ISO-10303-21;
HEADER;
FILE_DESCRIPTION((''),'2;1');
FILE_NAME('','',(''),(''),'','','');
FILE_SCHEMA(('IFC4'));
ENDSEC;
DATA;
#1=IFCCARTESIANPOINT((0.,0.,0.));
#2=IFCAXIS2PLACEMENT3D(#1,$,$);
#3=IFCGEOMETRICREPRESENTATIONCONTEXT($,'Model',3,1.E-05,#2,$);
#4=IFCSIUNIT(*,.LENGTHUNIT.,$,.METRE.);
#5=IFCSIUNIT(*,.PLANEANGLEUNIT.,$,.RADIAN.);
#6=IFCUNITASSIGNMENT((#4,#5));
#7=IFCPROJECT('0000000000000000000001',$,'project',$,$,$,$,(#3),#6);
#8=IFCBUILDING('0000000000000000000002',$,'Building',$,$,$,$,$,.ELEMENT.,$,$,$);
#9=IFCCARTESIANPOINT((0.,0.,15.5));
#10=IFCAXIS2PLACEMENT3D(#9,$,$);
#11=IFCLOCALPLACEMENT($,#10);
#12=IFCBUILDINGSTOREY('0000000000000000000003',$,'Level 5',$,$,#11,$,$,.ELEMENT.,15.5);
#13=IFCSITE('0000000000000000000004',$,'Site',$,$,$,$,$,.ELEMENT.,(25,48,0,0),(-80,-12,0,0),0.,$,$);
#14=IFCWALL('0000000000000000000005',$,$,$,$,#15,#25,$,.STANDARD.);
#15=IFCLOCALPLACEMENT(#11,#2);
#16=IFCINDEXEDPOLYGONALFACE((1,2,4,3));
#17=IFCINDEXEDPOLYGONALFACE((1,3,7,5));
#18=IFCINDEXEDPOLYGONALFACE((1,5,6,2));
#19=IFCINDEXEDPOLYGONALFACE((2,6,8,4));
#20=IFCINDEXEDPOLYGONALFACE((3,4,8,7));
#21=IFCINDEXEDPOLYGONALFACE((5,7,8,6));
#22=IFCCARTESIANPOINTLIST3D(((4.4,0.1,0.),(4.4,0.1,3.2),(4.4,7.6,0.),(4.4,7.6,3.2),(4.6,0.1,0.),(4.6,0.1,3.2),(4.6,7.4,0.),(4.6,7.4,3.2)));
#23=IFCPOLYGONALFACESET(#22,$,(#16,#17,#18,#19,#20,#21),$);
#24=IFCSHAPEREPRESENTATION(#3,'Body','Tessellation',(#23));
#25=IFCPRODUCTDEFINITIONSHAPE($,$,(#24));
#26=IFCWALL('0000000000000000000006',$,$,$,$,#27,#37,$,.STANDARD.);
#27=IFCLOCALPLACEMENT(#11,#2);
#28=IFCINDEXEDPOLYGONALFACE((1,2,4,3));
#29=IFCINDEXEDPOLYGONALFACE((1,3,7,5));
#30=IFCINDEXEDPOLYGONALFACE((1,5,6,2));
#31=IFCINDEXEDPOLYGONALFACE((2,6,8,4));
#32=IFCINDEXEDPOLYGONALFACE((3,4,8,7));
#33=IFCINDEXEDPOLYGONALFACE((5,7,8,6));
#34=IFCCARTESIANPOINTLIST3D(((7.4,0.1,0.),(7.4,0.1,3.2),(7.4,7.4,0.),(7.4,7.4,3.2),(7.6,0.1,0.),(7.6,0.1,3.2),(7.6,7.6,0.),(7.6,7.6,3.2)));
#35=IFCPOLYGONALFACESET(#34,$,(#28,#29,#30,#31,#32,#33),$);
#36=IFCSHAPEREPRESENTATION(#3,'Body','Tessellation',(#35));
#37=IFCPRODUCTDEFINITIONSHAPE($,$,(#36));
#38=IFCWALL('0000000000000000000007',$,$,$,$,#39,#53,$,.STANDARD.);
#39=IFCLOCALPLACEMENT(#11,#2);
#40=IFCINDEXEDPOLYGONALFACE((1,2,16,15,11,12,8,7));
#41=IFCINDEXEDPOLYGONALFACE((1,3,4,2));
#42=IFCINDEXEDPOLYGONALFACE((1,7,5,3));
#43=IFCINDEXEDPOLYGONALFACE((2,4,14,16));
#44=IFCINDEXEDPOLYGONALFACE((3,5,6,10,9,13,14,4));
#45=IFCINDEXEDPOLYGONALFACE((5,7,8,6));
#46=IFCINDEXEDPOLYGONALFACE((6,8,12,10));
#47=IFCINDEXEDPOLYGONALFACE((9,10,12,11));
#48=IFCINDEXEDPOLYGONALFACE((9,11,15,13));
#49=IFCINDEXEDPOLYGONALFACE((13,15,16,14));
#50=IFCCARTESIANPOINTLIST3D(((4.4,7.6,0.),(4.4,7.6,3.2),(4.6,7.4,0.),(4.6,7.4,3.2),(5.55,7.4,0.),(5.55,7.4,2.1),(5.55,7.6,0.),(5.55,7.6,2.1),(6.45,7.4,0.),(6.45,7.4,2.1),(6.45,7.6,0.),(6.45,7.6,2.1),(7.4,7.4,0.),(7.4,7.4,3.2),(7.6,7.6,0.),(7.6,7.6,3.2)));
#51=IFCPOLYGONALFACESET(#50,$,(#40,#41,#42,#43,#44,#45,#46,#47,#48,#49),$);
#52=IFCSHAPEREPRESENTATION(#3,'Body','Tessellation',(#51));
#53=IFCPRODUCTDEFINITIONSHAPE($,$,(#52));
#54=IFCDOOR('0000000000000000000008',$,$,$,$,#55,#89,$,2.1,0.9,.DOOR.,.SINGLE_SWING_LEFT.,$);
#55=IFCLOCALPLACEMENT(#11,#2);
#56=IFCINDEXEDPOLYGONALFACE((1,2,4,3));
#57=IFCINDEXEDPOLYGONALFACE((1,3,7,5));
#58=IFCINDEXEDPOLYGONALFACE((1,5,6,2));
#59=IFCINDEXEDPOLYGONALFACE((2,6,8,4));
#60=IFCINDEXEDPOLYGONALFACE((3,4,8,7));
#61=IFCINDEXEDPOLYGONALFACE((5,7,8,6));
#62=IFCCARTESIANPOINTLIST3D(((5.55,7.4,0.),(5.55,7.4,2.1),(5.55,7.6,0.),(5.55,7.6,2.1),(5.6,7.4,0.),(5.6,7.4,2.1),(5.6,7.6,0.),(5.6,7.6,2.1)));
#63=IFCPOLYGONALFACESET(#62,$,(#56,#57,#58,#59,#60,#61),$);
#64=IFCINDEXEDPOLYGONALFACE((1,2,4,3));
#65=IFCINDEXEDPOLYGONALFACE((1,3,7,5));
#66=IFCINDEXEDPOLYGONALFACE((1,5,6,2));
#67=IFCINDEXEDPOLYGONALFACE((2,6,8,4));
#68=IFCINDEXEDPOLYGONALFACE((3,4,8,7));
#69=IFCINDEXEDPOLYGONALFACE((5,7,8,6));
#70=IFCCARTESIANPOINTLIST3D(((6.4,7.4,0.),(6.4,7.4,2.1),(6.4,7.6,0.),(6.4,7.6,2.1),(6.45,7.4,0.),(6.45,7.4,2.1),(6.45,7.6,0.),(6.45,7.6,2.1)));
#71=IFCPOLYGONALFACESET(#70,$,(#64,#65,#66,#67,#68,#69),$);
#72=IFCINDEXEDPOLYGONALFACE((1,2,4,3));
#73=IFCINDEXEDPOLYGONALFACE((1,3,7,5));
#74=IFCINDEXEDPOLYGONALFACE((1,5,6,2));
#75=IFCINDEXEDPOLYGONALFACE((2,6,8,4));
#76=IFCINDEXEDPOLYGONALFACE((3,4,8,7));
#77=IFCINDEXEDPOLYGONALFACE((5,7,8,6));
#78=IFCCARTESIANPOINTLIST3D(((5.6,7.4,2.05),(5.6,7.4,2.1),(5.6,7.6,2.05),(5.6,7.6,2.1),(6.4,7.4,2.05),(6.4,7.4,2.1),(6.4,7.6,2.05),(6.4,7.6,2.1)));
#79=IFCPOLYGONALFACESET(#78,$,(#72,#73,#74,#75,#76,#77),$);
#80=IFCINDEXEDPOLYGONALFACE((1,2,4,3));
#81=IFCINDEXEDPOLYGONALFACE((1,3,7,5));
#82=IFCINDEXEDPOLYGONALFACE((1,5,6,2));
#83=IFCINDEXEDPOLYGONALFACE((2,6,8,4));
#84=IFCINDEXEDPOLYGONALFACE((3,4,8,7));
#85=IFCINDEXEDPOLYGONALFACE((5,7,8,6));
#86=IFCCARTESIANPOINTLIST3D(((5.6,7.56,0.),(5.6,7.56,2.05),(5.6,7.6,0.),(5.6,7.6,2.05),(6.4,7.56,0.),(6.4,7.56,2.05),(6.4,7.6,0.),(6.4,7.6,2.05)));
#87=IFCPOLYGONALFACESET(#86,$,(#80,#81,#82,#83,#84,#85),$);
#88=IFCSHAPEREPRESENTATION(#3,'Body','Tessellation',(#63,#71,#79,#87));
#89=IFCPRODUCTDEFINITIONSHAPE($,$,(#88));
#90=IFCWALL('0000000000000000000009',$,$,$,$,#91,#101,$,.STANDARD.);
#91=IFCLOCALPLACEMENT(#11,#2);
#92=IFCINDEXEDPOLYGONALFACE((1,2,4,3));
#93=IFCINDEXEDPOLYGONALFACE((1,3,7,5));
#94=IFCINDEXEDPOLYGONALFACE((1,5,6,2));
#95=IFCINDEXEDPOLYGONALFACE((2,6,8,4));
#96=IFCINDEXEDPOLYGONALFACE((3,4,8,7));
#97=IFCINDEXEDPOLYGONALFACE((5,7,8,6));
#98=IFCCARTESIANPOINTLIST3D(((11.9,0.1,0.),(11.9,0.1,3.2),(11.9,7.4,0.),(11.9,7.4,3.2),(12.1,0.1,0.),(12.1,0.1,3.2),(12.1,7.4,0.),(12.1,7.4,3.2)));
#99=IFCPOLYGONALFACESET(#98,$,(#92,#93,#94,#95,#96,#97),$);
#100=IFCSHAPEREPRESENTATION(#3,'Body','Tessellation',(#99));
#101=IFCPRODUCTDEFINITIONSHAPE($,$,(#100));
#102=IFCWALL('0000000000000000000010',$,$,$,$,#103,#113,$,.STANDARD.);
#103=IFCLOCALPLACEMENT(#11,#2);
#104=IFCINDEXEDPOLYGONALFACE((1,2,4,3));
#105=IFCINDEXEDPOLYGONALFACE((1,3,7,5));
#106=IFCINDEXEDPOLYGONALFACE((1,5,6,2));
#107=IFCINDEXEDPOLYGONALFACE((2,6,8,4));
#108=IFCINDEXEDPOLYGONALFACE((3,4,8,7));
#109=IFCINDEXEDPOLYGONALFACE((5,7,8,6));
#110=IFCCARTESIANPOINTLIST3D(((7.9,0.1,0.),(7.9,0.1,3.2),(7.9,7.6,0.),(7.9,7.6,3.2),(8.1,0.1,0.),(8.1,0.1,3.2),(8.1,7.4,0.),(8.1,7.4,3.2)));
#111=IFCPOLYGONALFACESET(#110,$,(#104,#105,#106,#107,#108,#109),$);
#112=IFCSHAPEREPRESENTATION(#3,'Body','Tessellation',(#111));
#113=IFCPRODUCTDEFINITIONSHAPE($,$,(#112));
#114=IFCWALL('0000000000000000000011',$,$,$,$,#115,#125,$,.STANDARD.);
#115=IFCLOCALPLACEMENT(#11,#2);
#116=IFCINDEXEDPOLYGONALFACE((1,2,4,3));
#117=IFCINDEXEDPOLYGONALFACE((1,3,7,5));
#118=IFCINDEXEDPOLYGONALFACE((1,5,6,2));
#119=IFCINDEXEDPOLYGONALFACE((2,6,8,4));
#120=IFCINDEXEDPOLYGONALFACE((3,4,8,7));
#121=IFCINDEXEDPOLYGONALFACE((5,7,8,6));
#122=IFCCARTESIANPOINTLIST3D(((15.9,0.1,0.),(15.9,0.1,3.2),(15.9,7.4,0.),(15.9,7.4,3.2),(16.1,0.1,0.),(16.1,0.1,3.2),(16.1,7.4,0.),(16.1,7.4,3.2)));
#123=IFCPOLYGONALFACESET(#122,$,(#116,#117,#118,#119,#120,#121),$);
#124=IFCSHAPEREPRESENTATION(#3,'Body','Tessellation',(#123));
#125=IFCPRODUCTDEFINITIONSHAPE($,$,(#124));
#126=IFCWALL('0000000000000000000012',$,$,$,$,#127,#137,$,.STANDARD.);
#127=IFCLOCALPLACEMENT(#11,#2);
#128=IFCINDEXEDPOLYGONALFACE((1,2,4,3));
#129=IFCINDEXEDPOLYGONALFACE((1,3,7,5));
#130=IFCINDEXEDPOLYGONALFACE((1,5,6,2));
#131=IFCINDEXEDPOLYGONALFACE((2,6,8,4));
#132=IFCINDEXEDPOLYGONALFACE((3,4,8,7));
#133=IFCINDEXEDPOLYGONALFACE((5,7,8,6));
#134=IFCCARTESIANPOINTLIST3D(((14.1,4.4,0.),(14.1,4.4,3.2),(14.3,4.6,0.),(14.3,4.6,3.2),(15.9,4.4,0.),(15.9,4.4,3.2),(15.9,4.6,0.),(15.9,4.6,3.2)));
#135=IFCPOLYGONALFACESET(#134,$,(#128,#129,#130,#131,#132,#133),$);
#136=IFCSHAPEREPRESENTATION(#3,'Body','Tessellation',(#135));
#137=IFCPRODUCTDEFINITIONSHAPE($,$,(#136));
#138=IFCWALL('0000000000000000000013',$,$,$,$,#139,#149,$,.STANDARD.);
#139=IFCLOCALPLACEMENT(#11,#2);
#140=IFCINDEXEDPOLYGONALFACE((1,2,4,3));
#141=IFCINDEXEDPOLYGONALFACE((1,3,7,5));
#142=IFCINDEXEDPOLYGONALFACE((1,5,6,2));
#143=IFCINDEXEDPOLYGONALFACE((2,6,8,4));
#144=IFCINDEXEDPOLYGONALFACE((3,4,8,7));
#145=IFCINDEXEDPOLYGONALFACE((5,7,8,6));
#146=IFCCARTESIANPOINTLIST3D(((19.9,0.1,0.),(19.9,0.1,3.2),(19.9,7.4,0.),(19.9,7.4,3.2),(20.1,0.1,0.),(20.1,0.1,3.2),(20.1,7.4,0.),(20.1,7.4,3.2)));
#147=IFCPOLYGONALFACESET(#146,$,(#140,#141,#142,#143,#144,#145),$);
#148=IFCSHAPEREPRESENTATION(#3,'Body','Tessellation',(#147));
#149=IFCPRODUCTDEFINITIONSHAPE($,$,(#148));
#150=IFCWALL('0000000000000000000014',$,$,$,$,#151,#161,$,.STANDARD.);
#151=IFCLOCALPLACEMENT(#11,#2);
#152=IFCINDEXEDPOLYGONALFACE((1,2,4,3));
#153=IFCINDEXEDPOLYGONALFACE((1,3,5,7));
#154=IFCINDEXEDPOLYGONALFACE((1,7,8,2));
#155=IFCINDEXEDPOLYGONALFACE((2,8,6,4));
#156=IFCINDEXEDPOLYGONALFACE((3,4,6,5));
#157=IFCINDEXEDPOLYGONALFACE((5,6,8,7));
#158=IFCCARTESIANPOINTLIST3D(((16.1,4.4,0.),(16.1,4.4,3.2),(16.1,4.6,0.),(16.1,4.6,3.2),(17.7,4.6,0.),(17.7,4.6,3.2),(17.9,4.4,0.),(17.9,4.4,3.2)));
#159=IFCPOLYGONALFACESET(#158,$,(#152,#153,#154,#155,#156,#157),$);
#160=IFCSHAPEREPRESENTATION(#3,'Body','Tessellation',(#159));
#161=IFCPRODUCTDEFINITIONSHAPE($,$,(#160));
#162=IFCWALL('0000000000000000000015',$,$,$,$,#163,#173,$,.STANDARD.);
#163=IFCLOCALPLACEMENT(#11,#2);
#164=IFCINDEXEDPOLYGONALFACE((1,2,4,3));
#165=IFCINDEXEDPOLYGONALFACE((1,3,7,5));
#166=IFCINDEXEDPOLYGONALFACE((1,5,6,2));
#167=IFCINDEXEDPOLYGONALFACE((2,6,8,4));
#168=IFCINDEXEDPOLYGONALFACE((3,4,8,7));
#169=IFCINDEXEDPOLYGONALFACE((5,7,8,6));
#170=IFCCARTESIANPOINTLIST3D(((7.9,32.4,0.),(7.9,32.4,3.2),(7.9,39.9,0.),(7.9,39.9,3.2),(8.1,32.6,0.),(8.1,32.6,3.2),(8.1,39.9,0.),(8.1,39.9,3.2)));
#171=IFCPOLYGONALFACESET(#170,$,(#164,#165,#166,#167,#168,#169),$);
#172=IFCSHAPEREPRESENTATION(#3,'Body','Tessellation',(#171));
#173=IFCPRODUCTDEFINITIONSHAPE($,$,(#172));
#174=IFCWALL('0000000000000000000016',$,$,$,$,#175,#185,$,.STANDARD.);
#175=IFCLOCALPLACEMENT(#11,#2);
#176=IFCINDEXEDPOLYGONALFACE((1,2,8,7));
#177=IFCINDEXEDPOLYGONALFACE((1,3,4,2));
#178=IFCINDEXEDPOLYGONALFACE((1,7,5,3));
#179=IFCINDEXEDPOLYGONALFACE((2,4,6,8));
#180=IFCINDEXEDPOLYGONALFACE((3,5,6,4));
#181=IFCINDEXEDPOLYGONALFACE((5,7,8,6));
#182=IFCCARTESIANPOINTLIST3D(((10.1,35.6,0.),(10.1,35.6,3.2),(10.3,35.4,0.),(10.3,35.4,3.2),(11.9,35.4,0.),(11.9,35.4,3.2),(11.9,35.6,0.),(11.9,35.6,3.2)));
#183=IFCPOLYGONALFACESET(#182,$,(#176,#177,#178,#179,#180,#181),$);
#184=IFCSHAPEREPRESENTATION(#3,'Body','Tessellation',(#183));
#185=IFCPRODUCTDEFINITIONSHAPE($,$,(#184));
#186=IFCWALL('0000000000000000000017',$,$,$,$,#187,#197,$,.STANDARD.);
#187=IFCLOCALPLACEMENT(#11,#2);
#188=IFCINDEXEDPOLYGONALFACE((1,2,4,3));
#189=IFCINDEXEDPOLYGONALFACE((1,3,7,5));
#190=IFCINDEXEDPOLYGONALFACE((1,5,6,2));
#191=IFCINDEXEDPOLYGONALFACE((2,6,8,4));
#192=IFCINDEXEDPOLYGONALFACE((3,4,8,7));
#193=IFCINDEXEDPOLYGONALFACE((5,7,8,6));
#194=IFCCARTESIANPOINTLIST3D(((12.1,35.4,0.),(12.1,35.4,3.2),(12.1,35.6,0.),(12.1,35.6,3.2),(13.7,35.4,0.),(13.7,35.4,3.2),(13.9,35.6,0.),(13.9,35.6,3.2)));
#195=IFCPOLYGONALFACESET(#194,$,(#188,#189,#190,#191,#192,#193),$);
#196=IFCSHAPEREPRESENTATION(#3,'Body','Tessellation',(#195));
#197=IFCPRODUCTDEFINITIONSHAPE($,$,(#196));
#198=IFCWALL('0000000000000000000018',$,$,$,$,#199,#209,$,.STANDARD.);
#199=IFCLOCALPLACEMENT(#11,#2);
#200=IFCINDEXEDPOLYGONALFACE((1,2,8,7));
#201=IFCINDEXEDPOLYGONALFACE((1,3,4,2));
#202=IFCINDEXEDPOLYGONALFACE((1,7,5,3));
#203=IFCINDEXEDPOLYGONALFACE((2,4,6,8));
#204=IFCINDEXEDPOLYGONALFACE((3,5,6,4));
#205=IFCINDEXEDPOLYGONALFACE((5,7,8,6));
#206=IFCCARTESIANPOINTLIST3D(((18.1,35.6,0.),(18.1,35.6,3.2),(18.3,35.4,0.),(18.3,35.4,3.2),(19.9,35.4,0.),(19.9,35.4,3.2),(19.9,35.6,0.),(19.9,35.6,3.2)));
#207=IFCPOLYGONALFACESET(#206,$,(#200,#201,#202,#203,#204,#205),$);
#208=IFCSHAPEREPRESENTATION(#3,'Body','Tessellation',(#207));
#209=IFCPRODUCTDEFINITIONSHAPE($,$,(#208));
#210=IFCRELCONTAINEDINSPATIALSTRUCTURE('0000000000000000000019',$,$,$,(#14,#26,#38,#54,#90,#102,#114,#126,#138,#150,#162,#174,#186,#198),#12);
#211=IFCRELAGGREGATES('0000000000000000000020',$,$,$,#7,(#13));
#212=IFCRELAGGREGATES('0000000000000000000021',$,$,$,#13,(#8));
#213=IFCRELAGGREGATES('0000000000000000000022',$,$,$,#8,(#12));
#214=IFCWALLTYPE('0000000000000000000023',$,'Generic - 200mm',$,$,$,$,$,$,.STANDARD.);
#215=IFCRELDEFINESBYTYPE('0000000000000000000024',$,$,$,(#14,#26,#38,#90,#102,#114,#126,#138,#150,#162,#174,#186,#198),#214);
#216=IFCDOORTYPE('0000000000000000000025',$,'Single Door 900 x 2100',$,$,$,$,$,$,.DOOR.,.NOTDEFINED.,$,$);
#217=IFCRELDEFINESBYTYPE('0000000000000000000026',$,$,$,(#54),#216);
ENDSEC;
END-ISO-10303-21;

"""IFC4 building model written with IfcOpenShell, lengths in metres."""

from ifc_helpers import new_model, si_unit, frame, frame_2d, origin, origin_with_axes, origin_2d, place, context, project, spatial, polyline, rectangle, outline, extrude, type_object, element, fill, save


model = new_model("IFC4")

# Units and contexts
model_context = context("Model", 3, precision=1e-05, world=origin())
ifc_project = project(units=[si_unit("LENGTHUNIT", "METRE"), si_unit("PLANEANGLEUNIT", "RADIAN")], contexts=[model_context])

# Site, building, storey
site = spatial("IfcSite", under=ifc_project, Name="Site", CompositionType="ELEMENT", RefLatitude=(25, 48, 0, 0), RefLongitude=(-80, -12, 0, 0), RefElevation=0.0)
building = spatial("IfcBuilding", under=site, Name="Building", CompositionType="ELEMENT")
storey_placement = place(None, frame((0.0, 0.0, 15.5)))
storey = spatial("IfcBuildingStorey", under=building, at=storey_placement, Name="Level 5", CompositionType="ELEMENT", Elevation=15.5)

# Shared definitions
wall_type = type_object("IfcWallType", Name="Generic - 200mm", PredefinedType="STANDARD")

# Walls
wall_1_placement = place(None, frame((4.5, 7.5, 15.5), z_axis=(0.0, 0.0, 1.0), x_axis=(0.0, -1.0, 0.0)))
element("IfcWall", 1, at=wall_1_placement, inside=storey, type_object=wall_type, PredefinedType="STANDARD", context=model_context, shape_type="SweptSolid", body=[
    extrude(outline(polyline([(-0.1, -0.1), (7.4, -0.1), (7.4, 0.1), (0.1, 0.1), (-0.1, -0.1)])), origin(), (0.0, 0.0, 1.0), 3.2),
])
wall_2_placement = place(None, frame((7.5, 7.5, 15.5), z_axis=(0.0, 0.0, 1.0), x_axis=(0.0, -1.0, 0.0)))
element("IfcWall", 2, at=wall_2_placement, inside=storey, type_object=wall_type, PredefinedType="STANDARD", context=model_context, shape_type="SweptSolid", body=[
    extrude(outline(polyline([(0.1, -0.1), (7.4, -0.1), (7.4, 0.1), (-0.1, 0.1), (0.1, -0.1)])), origin(), (0.0, 0.0, 1.0), 3.2),
])

# Wall, opening, door
wall_3_placement = place(None, frame((4.5, 7.5, 15.5), z_axis=(0.0, 0.0, 1.0), x_axis=(1.0, 0.0, 0.0)))
wall_3 = element("IfcWall", 3, at=wall_3_placement, inside=storey, type_object=wall_type, PredefinedType="STANDARD", context=model_context, shape_type="SweptSolid", body=[
    extrude(outline(polyline([(0.1, -0.1), (2.9, -0.1), (3.1, 0.1), (-0.1, 0.1), (0.1, -0.1)])), origin(), (0.0, 0.0, 1.0), 3.2),
])
opening_1_placement = place(wall_3_placement, frame((1.5, 0.0, 0.0), z_axis=(0.0, 0.0, 1.0), x_axis=(1.0, 0.0, 0.0)))
opening_1 = element("IfcOpeningElement", 4, at=opening_1_placement, cuts=wall_3, PredefinedType="OPENING", context=model_context, shape_type="SweptSolid", body=[
    extrude(rectangle(XDim=0.9, YDim=0.202, at=origin_2d()), origin(), (0.0, 0.0, 1.0), 2.1),
])
door_type = type_object("IfcDoorType", Name="Single Door 900 x 2100", OperationType="NOTDEFINED", PredefinedType="DOOR")
door_placement = place(opening_1_placement, origin_with_axes())
door = element("IfcDoor", 5, at=door_placement, inside=storey, type_object=door_type, OperationType="SINGLE_SWING_LEFT", OverallHeight=2.1, OverallWidth=0.9, PredefinedType="DOOR", context=model_context, shape_type="SweptSolid", body=[
    extrude(rectangle(XDim=0.05, YDim=0.2, at=frame_2d((-0.425, 0.0))), origin(), (0.0, 0.0, 1.0), 2.1),
    extrude(rectangle(XDim=0.05, YDim=0.2, at=frame_2d((0.425, 0.0))), origin(), (0.0, 0.0, 1.0), 2.1),
    extrude(rectangle(XDim=0.8, YDim=0.2, at=origin_2d()), frame((0.0, 0.0, 2.05)), (0.0, 0.0, 1.0), 0.05),
    extrude(rectangle(XDim=0.8, YDim=0.04, at=frame_2d((0.0, 0.08))), origin(), (0.0, 0.0, 1.0), 2.05),
])
fill(opening_1, door)

# Walls
wall_4_placement = place(None, frame((12.0, 7.5, 15.5), z_axis=(0.0, 0.0, 1.0), x_axis=(0.0, -1.0, 0.0)))
element("IfcWall", 6, at=wall_4_placement, inside=storey, type_object=wall_type, PredefinedType="STANDARD", context=model_context, shape_type="SweptSolid", body=[
    extrude(outline(polyline([(0.1, -0.1), (7.4, -0.1), (7.4, 0.1), (0.1, 0.1), (0.1, -0.1)])), origin(), (0.0, 0.0, 1.0), 3.2),
])
wall_5_placement = place(None, frame((8.0, 7.5, 15.5), z_axis=(0.0, 0.0, 1.0), x_axis=(0.0, -1.0, 0.0)))
element("IfcWall", 7, at=wall_5_placement, inside=storey, type_object=wall_type, PredefinedType="STANDARD", context=model_context, shape_type="SweptSolid", body=[
    extrude(outline(polyline([(-0.1, -0.1), (7.4, -0.1), (7.4, 0.1), (0.1, 0.1), (-0.1, -0.1)])), origin(), (0.0, 0.0, 1.0), 3.2),
])
wall_6_placement = place(None, frame((16.0, 7.5, 15.5), z_axis=(0.0, 0.0, 1.0), x_axis=(0.0, -1.0, 0.0)))
element("IfcWall", 8, at=wall_6_placement, inside=storey, type_object=wall_type, PredefinedType="STANDARD", context=model_context, shape_type="SweptSolid", body=[
    extrude(outline(polyline([(0.1, -0.1), (7.4, -0.1), (7.4, 0.1), (0.1, 0.1), (0.1, -0.1)])), origin(), (0.0, 0.0, 1.0), 3.2),
])
wall_7_placement = place(None, frame((14.2, 4.5, 15.5), z_axis=(0.0, 0.0, 1.0), x_axis=(1.0, 0.0, 0.0)))
element("IfcWall", 9, at=wall_7_placement, inside=storey, type_object=wall_type, PredefinedType="STANDARD", context=model_context, shape_type="SweptSolid", body=[
    extrude(outline(polyline([(-0.1, -0.1), (1.7, -0.1), (1.7, 0.1), (0.1, 0.1), (-0.1, -0.1)])), origin(), (0.0, 0.0, 1.0), 3.2),
])
wall_8_placement = place(None, frame((20.0, 7.5, 15.5), z_axis=(0.0, 0.0, 1.0), x_axis=(0.0, -1.0, 0.0)))
element("IfcWall", 10, at=wall_8_placement, inside=storey, type_object=wall_type, PredefinedType="STANDARD", context=model_context, shape_type="SweptSolid", body=[
    extrude(outline(polyline([(0.1, -0.1), (7.4, -0.1), (7.4, 0.1), (0.1, 0.1), (0.1, -0.1)])), origin(), (0.0, 0.0, 1.0), 3.2),
])
wall_9_placement = place(None, frame((17.8, 4.5, 15.5), z_axis=(0.0, 0.0, 1.0), x_axis=(-1.0, 0.0, 0.0)))
element("IfcWall", 11, at=wall_9_placement, inside=storey, type_object=wall_type, PredefinedType="STANDARD", context=model_context, shape_type="SweptSolid", body=[
    extrude(outline(polyline([(0.1, -0.1), (1.7, -0.1), (1.7, 0.1), (-0.1, 0.1), (0.1, -0.1)])), origin(), (0.0, 0.0, 1.0), 3.2),
])
wall_10_placement = place(None, frame((8.0, 32.5, 15.5), z_axis=(0.0, 0.0, 1.0), x_axis=(0.0, 1.0, 0.0)))
element("IfcWall", 12, at=wall_10_placement, inside=storey, type_object=wall_type, PredefinedType="STANDARD", context=model_context, shape_type="SweptSolid", body=[
    extrude(outline(polyline([(0.1, -0.1), (7.4, -0.1), (7.4, 0.1), (-0.1, 0.1), (0.1, -0.1)])), origin(), (0.0, 0.0, 1.0), 3.2),
])
wall_11_placement = place(None, frame((10.2, 35.5, 15.5), z_axis=(0.0, 0.0, 1.0), x_axis=(1.0, 0.0, 0.0)))
element("IfcWall", 13, at=wall_11_placement, inside=storey, type_object=wall_type, PredefinedType="STANDARD", context=model_context, shape_type="SweptSolid", body=[
    extrude(outline(polyline([(0.1, -0.1), (1.7, -0.1), (1.7, 0.1), (-0.1, 0.1), (0.1, -0.1)])), origin(), (0.0, 0.0, 1.0), 3.2),
])
wall_12_placement = place(None, frame((13.8, 35.5, 15.5), z_axis=(0.0, 0.0, 1.0), x_axis=(-1.0, 0.0, 0.0)))
element("IfcWall", 14, at=wall_12_placement, inside=storey, type_object=wall_type, PredefinedType="STANDARD", context=model_context, shape_type="SweptSolid", body=[
    extrude(outline(polyline([(-0.1, -0.1), (1.7, -0.1), (1.7, 0.1), (0.1, 0.1), (-0.1, -0.1)])), origin(), (0.0, 0.0, 1.0), 3.2),
])
wall_13_placement = place(None, frame((18.2, 35.5, 15.5), z_axis=(0.0, 0.0, 1.0), x_axis=(1.0, 0.0, 0.0)))
element("IfcWall", 15, at=wall_13_placement, inside=storey, type_object=wall_type, PredefinedType="STANDARD", context=model_context, shape_type="SweptSolid", body=[
    extrude(outline(polyline([(0.1, -0.1), (1.7, -0.1), (1.7, 0.1), (-0.1, 0.1), (0.1, -0.1)])), origin(), (0.0, 0.0, 1.0), 3.2),
])

save(model, "model.ifc")
